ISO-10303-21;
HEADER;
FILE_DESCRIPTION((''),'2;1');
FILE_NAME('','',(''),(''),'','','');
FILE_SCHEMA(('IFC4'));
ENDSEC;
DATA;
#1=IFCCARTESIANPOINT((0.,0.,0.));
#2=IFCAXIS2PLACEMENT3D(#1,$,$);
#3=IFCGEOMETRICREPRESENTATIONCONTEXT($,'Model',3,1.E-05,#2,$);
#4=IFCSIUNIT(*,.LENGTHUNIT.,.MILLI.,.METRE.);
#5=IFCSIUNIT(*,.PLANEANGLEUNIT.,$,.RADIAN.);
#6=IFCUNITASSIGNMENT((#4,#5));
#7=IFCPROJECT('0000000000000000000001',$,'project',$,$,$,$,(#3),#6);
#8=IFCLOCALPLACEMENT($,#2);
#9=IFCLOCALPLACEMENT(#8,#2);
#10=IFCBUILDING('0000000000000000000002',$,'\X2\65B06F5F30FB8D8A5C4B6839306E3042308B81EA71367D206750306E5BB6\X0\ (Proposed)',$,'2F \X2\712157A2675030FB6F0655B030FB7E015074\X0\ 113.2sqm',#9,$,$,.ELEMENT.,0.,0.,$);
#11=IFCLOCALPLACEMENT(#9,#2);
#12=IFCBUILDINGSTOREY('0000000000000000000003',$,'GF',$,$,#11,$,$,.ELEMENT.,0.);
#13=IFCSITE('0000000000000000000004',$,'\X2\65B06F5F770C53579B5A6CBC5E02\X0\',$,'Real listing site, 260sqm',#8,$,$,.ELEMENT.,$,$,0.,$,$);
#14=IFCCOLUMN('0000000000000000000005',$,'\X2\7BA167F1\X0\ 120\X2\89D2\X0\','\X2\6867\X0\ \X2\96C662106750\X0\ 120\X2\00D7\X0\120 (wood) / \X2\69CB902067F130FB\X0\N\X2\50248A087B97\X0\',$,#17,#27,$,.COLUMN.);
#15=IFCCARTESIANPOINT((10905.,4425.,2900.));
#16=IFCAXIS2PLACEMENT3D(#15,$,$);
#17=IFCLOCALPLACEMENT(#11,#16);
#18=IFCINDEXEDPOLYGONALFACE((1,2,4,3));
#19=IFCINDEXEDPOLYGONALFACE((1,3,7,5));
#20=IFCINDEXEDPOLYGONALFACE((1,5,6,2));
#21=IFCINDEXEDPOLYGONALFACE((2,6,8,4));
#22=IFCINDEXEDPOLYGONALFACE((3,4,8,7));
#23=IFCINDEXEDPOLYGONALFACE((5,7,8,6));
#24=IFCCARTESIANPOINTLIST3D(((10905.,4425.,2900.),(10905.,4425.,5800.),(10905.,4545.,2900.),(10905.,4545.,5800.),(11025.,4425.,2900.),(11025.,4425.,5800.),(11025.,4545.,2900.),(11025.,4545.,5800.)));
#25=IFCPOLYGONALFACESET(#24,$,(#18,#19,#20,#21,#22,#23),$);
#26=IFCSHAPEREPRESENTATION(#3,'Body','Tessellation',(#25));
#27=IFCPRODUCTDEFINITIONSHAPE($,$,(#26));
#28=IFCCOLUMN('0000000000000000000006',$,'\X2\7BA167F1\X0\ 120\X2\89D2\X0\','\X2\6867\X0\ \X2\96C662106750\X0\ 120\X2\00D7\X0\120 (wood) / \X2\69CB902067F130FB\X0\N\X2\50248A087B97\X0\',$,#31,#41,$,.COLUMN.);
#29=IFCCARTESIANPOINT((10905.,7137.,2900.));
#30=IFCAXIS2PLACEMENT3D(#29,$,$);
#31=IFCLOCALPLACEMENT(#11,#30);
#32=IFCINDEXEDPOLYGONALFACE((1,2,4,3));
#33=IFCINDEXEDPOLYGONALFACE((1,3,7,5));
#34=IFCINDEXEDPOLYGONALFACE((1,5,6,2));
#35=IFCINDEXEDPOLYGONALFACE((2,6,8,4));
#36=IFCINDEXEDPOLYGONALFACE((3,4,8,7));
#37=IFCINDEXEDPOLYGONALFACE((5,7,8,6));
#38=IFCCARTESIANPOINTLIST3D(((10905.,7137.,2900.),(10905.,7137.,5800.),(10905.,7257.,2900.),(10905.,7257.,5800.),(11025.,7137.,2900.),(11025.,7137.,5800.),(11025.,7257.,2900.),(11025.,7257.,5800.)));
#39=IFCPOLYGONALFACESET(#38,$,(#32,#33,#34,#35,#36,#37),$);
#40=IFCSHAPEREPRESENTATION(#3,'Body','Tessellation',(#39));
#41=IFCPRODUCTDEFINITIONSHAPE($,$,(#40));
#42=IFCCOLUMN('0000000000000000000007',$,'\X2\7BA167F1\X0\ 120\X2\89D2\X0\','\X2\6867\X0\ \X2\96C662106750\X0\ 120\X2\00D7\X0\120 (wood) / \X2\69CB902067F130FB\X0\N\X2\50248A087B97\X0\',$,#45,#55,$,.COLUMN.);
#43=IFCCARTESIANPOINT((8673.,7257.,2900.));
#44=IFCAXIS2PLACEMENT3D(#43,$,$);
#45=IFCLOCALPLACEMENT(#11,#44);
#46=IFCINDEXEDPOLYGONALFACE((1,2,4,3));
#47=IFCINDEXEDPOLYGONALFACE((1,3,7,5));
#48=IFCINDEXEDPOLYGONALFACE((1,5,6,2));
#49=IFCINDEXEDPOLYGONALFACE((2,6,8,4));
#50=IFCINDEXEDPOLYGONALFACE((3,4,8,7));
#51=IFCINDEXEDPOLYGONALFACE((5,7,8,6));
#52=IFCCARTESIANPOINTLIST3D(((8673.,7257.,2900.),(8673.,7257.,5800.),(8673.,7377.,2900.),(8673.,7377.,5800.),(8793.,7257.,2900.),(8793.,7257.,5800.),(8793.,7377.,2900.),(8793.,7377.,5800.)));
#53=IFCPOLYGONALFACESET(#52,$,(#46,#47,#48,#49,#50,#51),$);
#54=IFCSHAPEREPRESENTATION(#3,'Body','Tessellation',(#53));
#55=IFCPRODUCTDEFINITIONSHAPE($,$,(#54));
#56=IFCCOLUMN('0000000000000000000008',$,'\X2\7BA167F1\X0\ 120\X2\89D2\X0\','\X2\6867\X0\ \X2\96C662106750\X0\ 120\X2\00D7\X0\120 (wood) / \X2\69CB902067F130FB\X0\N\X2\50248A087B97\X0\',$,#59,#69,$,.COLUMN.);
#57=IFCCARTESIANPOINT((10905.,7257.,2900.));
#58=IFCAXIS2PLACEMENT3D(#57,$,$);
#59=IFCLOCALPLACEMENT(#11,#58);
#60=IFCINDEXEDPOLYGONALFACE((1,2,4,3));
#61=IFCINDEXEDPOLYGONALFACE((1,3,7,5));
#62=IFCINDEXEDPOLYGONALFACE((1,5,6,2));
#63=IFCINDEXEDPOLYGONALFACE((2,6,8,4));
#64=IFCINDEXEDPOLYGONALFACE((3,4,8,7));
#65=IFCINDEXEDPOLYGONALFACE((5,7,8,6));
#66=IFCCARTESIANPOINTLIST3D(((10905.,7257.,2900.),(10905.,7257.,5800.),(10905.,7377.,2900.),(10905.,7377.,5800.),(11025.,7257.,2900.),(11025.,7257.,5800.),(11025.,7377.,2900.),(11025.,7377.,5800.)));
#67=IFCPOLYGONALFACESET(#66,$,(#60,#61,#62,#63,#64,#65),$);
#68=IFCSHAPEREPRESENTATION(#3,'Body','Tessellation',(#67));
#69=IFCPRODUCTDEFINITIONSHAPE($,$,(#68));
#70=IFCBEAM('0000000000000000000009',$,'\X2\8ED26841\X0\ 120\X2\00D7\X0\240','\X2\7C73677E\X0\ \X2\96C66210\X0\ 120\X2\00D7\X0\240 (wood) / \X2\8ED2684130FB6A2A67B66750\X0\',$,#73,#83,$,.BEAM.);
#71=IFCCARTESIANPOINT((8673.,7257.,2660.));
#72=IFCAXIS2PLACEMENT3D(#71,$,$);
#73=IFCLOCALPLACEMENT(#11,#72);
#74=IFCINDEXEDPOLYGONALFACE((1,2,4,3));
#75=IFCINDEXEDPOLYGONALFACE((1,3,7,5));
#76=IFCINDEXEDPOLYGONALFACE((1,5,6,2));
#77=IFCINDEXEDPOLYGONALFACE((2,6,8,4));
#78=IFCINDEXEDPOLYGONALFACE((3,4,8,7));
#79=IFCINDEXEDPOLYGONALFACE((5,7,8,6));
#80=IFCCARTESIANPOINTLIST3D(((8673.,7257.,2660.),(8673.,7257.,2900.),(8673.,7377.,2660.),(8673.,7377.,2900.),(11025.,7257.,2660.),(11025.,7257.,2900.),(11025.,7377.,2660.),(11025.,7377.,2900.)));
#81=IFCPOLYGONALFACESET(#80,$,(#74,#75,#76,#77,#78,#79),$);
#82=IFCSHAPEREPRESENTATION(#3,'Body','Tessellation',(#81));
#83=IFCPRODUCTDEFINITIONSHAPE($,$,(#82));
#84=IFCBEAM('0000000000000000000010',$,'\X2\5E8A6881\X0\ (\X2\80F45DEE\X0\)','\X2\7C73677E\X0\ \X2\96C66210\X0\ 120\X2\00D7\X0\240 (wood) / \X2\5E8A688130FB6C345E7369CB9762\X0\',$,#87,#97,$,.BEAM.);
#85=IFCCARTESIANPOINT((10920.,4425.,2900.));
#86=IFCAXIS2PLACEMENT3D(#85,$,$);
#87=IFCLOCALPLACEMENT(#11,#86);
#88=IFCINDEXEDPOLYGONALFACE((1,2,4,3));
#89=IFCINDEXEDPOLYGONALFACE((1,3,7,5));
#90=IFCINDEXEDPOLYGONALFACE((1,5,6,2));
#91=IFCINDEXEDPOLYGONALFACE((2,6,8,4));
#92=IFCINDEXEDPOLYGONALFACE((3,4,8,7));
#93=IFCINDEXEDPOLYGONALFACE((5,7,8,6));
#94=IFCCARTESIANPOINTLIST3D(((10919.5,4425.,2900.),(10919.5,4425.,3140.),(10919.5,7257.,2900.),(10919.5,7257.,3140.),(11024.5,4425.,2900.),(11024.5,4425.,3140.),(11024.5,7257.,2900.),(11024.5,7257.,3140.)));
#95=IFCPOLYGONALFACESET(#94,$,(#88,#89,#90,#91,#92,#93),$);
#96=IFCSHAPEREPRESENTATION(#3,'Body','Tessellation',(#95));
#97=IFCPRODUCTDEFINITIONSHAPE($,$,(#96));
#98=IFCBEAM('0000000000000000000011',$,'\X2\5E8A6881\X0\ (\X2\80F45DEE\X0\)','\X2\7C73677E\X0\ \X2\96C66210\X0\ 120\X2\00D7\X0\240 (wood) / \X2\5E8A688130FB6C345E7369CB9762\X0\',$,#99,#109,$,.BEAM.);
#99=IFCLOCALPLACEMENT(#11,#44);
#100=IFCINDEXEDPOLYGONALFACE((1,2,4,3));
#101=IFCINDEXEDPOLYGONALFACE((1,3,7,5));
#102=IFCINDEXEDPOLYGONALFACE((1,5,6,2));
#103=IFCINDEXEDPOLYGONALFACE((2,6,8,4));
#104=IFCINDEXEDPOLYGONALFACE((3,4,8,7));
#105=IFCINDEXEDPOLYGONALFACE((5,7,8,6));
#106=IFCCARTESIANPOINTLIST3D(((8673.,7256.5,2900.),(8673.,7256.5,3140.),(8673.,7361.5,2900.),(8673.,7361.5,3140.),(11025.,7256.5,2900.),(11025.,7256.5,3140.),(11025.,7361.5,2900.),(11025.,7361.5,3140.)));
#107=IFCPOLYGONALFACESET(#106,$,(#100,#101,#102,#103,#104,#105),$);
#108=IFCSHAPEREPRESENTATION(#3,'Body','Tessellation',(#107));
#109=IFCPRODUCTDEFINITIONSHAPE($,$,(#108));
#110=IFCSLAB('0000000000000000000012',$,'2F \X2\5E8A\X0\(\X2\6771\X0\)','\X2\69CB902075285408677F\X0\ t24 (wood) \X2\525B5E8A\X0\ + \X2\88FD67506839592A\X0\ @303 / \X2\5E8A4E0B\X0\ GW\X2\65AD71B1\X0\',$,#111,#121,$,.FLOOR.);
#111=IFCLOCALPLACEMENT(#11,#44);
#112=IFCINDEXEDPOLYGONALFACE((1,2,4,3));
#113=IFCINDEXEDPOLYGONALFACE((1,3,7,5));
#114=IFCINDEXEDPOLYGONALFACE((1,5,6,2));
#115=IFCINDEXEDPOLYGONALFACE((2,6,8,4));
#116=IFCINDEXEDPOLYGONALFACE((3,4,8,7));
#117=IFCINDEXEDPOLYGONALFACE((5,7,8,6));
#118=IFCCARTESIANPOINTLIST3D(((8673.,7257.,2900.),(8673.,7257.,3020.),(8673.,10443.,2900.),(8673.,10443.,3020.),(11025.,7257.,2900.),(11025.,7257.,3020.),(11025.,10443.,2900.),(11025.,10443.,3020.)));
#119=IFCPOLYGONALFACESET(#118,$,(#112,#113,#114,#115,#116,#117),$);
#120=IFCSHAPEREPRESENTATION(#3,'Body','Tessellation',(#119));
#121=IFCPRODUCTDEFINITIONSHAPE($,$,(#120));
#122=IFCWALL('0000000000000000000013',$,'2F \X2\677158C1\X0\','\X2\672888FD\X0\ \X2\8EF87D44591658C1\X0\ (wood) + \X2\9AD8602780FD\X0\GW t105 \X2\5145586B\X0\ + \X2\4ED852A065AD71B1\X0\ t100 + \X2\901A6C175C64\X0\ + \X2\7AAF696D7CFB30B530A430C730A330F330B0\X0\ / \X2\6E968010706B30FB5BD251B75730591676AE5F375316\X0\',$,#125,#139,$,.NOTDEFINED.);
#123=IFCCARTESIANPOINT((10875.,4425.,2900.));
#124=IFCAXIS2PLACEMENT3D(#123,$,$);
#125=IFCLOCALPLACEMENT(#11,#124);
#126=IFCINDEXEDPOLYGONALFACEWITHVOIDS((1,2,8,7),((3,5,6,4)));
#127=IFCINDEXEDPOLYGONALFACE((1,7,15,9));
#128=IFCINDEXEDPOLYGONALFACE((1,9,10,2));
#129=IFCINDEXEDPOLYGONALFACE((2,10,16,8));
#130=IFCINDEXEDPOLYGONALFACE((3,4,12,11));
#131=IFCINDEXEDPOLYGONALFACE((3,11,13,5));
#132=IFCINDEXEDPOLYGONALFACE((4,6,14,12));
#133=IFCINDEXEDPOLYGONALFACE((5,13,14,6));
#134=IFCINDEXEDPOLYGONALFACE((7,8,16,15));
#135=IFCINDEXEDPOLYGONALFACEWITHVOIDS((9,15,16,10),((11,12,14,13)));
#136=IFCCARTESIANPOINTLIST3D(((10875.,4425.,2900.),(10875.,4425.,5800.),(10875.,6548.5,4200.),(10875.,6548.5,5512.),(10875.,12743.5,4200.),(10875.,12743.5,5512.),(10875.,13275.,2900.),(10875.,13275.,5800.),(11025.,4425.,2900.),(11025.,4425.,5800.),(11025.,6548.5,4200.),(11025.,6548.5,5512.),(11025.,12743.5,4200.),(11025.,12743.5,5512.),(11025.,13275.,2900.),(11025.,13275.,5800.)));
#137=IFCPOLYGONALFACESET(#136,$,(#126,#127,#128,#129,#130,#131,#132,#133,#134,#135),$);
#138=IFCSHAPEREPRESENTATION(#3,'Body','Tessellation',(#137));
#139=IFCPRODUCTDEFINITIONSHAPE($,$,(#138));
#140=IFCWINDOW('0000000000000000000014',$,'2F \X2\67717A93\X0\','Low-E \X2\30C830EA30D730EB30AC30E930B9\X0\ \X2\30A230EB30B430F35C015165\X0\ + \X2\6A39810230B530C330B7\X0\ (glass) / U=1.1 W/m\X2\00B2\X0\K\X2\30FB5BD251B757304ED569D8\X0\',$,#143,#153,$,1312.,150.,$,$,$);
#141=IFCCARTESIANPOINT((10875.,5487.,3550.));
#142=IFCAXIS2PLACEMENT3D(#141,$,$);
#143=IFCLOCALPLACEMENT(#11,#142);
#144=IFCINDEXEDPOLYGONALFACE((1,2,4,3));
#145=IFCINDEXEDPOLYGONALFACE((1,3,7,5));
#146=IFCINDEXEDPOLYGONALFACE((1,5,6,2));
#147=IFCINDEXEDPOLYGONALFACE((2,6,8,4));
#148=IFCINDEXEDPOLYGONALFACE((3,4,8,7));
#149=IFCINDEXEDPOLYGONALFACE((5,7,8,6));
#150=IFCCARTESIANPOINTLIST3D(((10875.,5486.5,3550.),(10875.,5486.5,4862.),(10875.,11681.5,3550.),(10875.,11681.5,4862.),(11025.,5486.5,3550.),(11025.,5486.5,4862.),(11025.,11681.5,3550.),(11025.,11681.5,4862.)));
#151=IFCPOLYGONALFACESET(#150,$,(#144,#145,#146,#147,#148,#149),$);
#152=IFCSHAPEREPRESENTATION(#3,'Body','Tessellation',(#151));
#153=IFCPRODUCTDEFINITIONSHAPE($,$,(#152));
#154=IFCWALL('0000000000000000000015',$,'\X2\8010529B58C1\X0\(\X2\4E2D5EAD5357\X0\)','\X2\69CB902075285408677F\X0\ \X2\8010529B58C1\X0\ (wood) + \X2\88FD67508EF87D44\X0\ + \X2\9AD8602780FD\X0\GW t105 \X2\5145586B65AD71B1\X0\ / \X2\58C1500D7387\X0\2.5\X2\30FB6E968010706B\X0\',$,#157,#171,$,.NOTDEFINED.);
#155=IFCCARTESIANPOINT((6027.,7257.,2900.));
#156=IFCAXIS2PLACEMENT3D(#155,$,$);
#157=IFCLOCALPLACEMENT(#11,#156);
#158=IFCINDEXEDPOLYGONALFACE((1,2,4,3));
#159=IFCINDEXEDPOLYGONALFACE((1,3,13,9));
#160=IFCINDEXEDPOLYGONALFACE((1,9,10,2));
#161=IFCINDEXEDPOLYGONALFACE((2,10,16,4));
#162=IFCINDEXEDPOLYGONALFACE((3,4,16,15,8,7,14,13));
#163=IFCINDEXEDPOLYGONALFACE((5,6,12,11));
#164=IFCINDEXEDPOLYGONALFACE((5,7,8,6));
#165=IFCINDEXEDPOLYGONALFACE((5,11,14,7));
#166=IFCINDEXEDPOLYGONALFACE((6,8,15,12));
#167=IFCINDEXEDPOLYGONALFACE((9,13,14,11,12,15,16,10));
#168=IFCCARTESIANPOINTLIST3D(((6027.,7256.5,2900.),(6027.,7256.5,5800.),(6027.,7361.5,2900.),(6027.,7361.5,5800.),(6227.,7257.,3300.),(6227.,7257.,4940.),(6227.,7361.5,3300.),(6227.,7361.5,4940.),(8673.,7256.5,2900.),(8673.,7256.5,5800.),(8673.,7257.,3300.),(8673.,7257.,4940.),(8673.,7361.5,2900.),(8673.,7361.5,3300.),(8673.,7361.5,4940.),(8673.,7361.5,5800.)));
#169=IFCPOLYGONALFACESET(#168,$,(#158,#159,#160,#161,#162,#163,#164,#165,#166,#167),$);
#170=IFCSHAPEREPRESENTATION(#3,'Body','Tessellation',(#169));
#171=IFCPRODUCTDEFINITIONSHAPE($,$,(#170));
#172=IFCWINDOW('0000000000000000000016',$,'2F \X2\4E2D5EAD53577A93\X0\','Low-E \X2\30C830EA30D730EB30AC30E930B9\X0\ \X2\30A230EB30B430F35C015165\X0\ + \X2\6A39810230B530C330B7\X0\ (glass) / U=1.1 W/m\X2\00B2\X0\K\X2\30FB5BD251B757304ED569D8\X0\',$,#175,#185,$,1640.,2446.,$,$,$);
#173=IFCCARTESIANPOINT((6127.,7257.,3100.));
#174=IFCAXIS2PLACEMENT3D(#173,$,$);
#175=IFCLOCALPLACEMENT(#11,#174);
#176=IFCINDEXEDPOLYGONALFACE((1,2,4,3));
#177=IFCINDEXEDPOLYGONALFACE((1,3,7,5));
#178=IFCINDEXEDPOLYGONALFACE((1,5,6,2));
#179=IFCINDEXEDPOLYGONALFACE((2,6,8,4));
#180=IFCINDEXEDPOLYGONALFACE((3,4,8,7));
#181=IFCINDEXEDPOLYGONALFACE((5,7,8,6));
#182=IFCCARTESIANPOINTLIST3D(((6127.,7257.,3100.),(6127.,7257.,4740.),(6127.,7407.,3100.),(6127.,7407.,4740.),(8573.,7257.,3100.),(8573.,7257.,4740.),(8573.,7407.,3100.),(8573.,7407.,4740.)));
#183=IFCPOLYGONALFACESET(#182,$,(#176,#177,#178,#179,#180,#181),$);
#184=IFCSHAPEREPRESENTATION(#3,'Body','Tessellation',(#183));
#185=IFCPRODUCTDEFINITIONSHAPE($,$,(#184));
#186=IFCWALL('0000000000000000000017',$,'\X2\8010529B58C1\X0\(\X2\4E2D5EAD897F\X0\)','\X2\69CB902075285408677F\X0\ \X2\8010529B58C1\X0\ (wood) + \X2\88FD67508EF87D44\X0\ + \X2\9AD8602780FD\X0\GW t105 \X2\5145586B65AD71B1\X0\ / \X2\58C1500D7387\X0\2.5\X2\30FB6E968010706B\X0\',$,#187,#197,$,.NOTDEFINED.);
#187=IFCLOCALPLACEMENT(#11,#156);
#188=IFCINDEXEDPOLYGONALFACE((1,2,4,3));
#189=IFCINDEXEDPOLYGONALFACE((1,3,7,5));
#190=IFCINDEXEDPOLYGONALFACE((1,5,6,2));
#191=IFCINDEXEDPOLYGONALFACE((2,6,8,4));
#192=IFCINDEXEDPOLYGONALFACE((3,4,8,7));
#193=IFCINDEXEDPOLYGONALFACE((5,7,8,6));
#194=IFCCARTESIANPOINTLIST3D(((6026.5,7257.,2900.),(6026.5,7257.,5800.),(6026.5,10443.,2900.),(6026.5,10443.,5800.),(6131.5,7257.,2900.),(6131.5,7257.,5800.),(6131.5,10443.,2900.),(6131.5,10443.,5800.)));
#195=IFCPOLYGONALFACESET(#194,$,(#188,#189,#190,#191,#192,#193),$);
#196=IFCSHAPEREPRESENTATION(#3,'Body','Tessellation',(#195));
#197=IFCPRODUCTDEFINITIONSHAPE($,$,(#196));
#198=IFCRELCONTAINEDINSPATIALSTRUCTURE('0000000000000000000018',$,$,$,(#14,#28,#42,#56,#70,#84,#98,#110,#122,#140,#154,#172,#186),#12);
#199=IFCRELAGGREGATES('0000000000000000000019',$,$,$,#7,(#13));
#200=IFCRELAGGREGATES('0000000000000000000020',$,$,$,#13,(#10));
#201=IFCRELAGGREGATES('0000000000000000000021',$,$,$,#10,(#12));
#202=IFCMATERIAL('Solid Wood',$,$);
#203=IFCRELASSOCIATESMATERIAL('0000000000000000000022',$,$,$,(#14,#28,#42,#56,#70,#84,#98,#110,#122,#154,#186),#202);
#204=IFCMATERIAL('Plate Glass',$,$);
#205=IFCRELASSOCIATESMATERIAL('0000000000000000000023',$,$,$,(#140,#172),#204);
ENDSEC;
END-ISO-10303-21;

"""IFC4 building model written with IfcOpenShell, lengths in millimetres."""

from ifc_helpers import new_model, si_unit, frame, frame_2d, origin, place, context, project, spatial, rectangle, extrude, material, element, fill, save


model = new_model("IFC4")

# Units and contexts
model_context = context("Model", 3, precision=1e-05, world=origin())
ifc_project = project(units=[si_unit("LENGTHUNIT", "METRE", prefix="MILLI"), si_unit("PLANEANGLEUNIT", "RADIAN")], contexts=[model_context])

# Site, building, storey
site_placement = place(None, origin())
site = spatial("IfcSite", under=ifc_project, at=site_placement, Name="新潟県南魚沼市", ObjectType="Real listing site, 260sqm", CompositionType="ELEMENT", RefElevation=0.0)
building_placement = place(site_placement, origin())
building = spatial("IfcBuilding", under=site, at=building_placement, Name="新潟・越屋根のある自然素材の家 (Proposed)", ObjectType="2F 無垢材・漆喰・縁側 113.2sqm", CompositionType="ELEMENT", ElevationOfRefHeight=0.0, ElevationOfTerrain=0.0)
storey_placement = place(building_placement, origin())
storey = spatial("IfcBuildingStorey", under=building, at=storey_placement, Name="GF", CompositionType="ELEMENT", Elevation=0.0)

# Columns
ifc_material_1 = material(Name="Solid Wood")
column_1_placement = place(storey_placement, frame((10905.0, 4425.0, 2900.0)))
element("IfcColumn", 1, at=column_1_placement, inside=storey, material=ifc_material_1, Name="管柱 120角", Description="桧 集成材 120×120 (wood) / 構造柱・N値計算", PredefinedType="COLUMN", context=model_context, shape_type="SweptSolid", body=[
    extrude(rectangle(XDim=120.0, YDim=120.0, at=frame_2d((60.0, 60.0))), frame((10905.0, 4425.0, 2900.0)), (0.0, 0.0, 1.0), 2900.0),
])
column_2_placement = place(storey_placement, frame((10905.0, 7137.0, 2900.0)))
element("IfcColumn", 2, at=column_2_placement, inside=storey, material=ifc_material_1, Name="管柱 120角", Description="桧 集成材 120×120 (wood) / 構造柱・N値計算", PredefinedType="COLUMN", context=model_context, shape_type="SweptSolid", body=[
    extrude(rectangle(XDim=120.0, YDim=120.0, at=frame_2d((60.0, 60.0))), frame((10905.0, 7137.0, 2900.0)), (0.0, 0.0, 1.0), 2900.0),
])
column_3_placement = place(storey_placement, frame((8673.0, 7257.0, 2900.0)))
element("IfcColumn", 3, at=column_3_placement, inside=storey, material=ifc_material_1, Name="管柱 120角", Description="桧 集成材 120×120 (wood) / 構造柱・N値計算", PredefinedType="COLUMN", context=model_context, shape_type="SweptSolid", body=[
    extrude(rectangle(XDim=120.0, YDim=120.0, at=frame_2d((60.0, 60.0))), frame((8673.0, 7257.0, 2900.0)), (0.0, 0.0, 1.0), 2900.0),
])
column_4_placement = place(storey_placement, frame((10905.0, 7257.0, 2900.0)))
element("IfcColumn", 4, at=column_4_placement, inside=storey, material=ifc_material_1, Name="管柱 120角", Description="桧 集成材 120×120 (wood) / 構造柱・N値計算", PredefinedType="COLUMN", context=model_context, shape_type="SweptSolid", body=[
    extrude(rectangle(XDim=120.0, YDim=120.0, at=frame_2d((60.0, 60.0))), frame((10905.0, 7257.0, 2900.0)), (0.0, 0.0, 1.0), 2900.0),
])

# Beams
beam_1_placement = place(storey_placement, frame((8673.0, 7257.0, 2660.0)))
element("IfcBeam", 5, at=beam_1_placement, inside=storey, material=ifc_material_1, Name="軒桁 120×240", Description="米松 集成 120×240 (wood) / 軒桁・横架材", PredefinedType="BEAM", context=model_context, shape_type="SweptSolid", body=[
    extrude(rectangle(XDim=2352.0, YDim=120.0, at=frame_2d((1176.0, 60.0))), frame((8673.0, 7257.0, 2660.0)), (0.0, 0.0, 1.0), 240.0),
])
beam_2_placement = place(storey_placement, frame((10920.0, 4425.0, 2900.0)))
element("IfcBeam", 6, at=beam_2_placement, inside=storey, material=ifc_material_1, Name="床梁 (胴差)", Description="米松 集成 120×240 (wood) / 床梁・水平構面", PredefinedType="BEAM", context=model_context, shape_type="SweptSolid", body=[
    extrude(rectangle(XDim=105.0, YDim=2832.0, at=frame_2d((52.0, 1416.0))), frame((10920.0, 4425.0, 2900.0)), (0.0, 0.0, 1.0), 240.0),
])
beam_3_placement = place(storey_placement, frame((8673.0, 7257.0, 2900.0)))
element("IfcBeam", 7, at=beam_3_placement, inside=storey, material=ifc_material_1, Name="床梁 (胴差)", Description="米松 集成 120×240 (wood) / 床梁・水平構面", PredefinedType="BEAM", context=model_context, shape_type="SweptSolid", body=[
    extrude(rectangle(XDim=2352.0, YDim=105.0, at=frame_2d((1176.0, 52.0))), frame((8673.0, 7257.0, 2900.0)), (0.0, 0.0, 1.0), 240.0),
])

# Slab
slab_placement = place(storey_placement, frame((8673.0, 7257.0, 2900.0)))
element("IfcSlab", 8, at=slab_placement, inside=storey, material=ifc_material_1, Name="2F 床(東)", Description="構造用合板 t24 (wood) 剛床 + 製材根太 @303 / 床下 GW断熱", PredefinedType="FLOOR", context=model_context, shape_type="SweptSolid", body=[
    extrude(rectangle(XDim=2352.0, YDim=3186.0, at=frame_2d((1176.0, 1593.0))), frame((8673.0, 7257.0, 2900.0)), (0.0, 0.0, 1.0), 120.0),
])

# Walls, openings, windows
wall_1_placement = place(storey_placement, frame((10875.0, 4425.0, 2900.0)))
wall_1 = element("IfcWall", 9, at=wall_1_placement, inside=storey, material=ifc_material_1, Name="2F 東壁", Description="木製 軸組外壁 (wood) + 高性能GW t105 充填 + 付加断熱 t100 + 通気層 + 窯業系サイディング / 準耐火・寒冷地外皮強化", PredefinedType="NOTDEFINED", context=model_context, shape_type="SweptSolid", body=[
    extrude(rectangle(XDim=150.0, YDim=8850.0, at=frame_2d((75.0, 4425.0))), frame((10875.0, 4425.0, 2900.0)), (0.0, 0.0, 1.0), 2900.0),
])
opening_1_placement = place(storey_placement, frame((10875.0, 5487.0, 3550.0)))
opening_1 = element("IfcOpeningElement", 10, at=opening_1_placement, cuts=wall_1, PredefinedType="NOTDEFINED", context=model_context, shape_type="SweptSolid", body=[
    extrude(rectangle(XDim=150.0, YDim=6195.0, at=frame_2d((75.0, 3097.0))), frame((10875.0, 5487.0, 3550.0)), (0.0, 0.0, 1.0), 1312.0),
])
ifc_material_2 = material(Name="Plate Glass")
window_1_placement = place(storey_placement, frame((10875.0, 5487.0, 3550.0)))
window_1 = element("IfcWindow", 11, at=window_1_placement, inside=storey, material=ifc_material_2, Name="2F 東窓", Description="Low-E トリプルガラス アルゴン封入 + 樹脂サッシ (glass) / U=1.1 W/m²K・寒冷地仕様", OverallHeight=1312.0, OverallWidth=150.0, context=model_context, shape_type="SweptSolid", body=[
    extrude(rectangle(XDim=150.0, YDim=6195.0, at=frame_2d((75.0, 3097.0))), frame((10875.0, 5487.0, 3550.0)), (0.0, 0.0, 1.0), 1312.0),
])
fill(opening_1, window_1)
wall_2_placement = place(storey_placement, frame((6027.0, 7257.0, 2900.0)))
wall_2 = element("IfcWall", 12, at=wall_2_placement, inside=storey, material=ifc_material_1, Name="耐力壁(中庭南)", Description="構造用合板 耐力壁 (wood) + 製材軸組 + 高性能GW t105 充填断熱 / 壁倍率2.5・準耐火", PredefinedType="NOTDEFINED", context=model_context, shape_type="SweptSolid", body=[
    extrude(rectangle(XDim=2646.0, YDim=105.0, at=frame_2d((1323.0, 52.0))), frame((6027.0, 7257.0, 2900.0)), (0.0, 0.0, 1.0), 2900.0),
])
opening_2_placement = place(storey_placement, frame((6127.0, 7257.0, 3100.0)))
opening_2 = element("IfcOpeningElement", 13, at=opening_2_placement, cuts=wall_2, PredefinedType="NOTDEFINED", context=model_context, shape_type="SweptSolid", body=[
    extrude(rectangle(XDim=2446.0, YDim=150.0, at=frame_2d((1223.0, 75.0))), frame((6127.0, 7257.0, 3100.0)), (0.0, 0.0, 1.0), 1640.0),
])
window_2_placement = place(storey_placement, frame((6127.0, 7257.0, 3100.0)))
window_2 = element("IfcWindow", 14, at=window_2_placement, inside=storey, material=ifc_material_2, Name="2F 中庭南窓", Description="Low-E トリプルガラス アルゴン封入 + 樹脂サッシ (glass) / U=1.1 W/m²K・寒冷地仕様", OverallHeight=1640.0, OverallWidth=2446.0, context=model_context, shape_type="SweptSolid", body=[
    extrude(rectangle(XDim=2446.0, YDim=150.0, at=frame_2d((1223.0, 75.0))), frame((6127.0, 7257.0, 3100.0)), (0.0, 0.0, 1.0), 1640.0),
])
fill(opening_2, window_2)

# Wall
wall_3_placement = place(storey_placement, frame((6027.0, 7257.0, 2900.0)))
element("IfcWall", 15, at=wall_3_placement, inside=storey, material=ifc_material_1, Name="耐力壁(中庭西)", Description="構造用合板 耐力壁 (wood) + 製材軸組 + 高性能GW t105 充填断熱 / 壁倍率2.5・準耐火", PredefinedType="NOTDEFINED", context=model_context, shape_type="SweptSolid", body=[
    extrude(rectangle(XDim=105.0, YDim=3186.0, at=frame_2d((52.0, 1593.0))), frame((6027.0, 7257.0, 2900.0)), (0.0, 0.0, 1.0), 2900.0),
])

save(model, "model.ifc")
